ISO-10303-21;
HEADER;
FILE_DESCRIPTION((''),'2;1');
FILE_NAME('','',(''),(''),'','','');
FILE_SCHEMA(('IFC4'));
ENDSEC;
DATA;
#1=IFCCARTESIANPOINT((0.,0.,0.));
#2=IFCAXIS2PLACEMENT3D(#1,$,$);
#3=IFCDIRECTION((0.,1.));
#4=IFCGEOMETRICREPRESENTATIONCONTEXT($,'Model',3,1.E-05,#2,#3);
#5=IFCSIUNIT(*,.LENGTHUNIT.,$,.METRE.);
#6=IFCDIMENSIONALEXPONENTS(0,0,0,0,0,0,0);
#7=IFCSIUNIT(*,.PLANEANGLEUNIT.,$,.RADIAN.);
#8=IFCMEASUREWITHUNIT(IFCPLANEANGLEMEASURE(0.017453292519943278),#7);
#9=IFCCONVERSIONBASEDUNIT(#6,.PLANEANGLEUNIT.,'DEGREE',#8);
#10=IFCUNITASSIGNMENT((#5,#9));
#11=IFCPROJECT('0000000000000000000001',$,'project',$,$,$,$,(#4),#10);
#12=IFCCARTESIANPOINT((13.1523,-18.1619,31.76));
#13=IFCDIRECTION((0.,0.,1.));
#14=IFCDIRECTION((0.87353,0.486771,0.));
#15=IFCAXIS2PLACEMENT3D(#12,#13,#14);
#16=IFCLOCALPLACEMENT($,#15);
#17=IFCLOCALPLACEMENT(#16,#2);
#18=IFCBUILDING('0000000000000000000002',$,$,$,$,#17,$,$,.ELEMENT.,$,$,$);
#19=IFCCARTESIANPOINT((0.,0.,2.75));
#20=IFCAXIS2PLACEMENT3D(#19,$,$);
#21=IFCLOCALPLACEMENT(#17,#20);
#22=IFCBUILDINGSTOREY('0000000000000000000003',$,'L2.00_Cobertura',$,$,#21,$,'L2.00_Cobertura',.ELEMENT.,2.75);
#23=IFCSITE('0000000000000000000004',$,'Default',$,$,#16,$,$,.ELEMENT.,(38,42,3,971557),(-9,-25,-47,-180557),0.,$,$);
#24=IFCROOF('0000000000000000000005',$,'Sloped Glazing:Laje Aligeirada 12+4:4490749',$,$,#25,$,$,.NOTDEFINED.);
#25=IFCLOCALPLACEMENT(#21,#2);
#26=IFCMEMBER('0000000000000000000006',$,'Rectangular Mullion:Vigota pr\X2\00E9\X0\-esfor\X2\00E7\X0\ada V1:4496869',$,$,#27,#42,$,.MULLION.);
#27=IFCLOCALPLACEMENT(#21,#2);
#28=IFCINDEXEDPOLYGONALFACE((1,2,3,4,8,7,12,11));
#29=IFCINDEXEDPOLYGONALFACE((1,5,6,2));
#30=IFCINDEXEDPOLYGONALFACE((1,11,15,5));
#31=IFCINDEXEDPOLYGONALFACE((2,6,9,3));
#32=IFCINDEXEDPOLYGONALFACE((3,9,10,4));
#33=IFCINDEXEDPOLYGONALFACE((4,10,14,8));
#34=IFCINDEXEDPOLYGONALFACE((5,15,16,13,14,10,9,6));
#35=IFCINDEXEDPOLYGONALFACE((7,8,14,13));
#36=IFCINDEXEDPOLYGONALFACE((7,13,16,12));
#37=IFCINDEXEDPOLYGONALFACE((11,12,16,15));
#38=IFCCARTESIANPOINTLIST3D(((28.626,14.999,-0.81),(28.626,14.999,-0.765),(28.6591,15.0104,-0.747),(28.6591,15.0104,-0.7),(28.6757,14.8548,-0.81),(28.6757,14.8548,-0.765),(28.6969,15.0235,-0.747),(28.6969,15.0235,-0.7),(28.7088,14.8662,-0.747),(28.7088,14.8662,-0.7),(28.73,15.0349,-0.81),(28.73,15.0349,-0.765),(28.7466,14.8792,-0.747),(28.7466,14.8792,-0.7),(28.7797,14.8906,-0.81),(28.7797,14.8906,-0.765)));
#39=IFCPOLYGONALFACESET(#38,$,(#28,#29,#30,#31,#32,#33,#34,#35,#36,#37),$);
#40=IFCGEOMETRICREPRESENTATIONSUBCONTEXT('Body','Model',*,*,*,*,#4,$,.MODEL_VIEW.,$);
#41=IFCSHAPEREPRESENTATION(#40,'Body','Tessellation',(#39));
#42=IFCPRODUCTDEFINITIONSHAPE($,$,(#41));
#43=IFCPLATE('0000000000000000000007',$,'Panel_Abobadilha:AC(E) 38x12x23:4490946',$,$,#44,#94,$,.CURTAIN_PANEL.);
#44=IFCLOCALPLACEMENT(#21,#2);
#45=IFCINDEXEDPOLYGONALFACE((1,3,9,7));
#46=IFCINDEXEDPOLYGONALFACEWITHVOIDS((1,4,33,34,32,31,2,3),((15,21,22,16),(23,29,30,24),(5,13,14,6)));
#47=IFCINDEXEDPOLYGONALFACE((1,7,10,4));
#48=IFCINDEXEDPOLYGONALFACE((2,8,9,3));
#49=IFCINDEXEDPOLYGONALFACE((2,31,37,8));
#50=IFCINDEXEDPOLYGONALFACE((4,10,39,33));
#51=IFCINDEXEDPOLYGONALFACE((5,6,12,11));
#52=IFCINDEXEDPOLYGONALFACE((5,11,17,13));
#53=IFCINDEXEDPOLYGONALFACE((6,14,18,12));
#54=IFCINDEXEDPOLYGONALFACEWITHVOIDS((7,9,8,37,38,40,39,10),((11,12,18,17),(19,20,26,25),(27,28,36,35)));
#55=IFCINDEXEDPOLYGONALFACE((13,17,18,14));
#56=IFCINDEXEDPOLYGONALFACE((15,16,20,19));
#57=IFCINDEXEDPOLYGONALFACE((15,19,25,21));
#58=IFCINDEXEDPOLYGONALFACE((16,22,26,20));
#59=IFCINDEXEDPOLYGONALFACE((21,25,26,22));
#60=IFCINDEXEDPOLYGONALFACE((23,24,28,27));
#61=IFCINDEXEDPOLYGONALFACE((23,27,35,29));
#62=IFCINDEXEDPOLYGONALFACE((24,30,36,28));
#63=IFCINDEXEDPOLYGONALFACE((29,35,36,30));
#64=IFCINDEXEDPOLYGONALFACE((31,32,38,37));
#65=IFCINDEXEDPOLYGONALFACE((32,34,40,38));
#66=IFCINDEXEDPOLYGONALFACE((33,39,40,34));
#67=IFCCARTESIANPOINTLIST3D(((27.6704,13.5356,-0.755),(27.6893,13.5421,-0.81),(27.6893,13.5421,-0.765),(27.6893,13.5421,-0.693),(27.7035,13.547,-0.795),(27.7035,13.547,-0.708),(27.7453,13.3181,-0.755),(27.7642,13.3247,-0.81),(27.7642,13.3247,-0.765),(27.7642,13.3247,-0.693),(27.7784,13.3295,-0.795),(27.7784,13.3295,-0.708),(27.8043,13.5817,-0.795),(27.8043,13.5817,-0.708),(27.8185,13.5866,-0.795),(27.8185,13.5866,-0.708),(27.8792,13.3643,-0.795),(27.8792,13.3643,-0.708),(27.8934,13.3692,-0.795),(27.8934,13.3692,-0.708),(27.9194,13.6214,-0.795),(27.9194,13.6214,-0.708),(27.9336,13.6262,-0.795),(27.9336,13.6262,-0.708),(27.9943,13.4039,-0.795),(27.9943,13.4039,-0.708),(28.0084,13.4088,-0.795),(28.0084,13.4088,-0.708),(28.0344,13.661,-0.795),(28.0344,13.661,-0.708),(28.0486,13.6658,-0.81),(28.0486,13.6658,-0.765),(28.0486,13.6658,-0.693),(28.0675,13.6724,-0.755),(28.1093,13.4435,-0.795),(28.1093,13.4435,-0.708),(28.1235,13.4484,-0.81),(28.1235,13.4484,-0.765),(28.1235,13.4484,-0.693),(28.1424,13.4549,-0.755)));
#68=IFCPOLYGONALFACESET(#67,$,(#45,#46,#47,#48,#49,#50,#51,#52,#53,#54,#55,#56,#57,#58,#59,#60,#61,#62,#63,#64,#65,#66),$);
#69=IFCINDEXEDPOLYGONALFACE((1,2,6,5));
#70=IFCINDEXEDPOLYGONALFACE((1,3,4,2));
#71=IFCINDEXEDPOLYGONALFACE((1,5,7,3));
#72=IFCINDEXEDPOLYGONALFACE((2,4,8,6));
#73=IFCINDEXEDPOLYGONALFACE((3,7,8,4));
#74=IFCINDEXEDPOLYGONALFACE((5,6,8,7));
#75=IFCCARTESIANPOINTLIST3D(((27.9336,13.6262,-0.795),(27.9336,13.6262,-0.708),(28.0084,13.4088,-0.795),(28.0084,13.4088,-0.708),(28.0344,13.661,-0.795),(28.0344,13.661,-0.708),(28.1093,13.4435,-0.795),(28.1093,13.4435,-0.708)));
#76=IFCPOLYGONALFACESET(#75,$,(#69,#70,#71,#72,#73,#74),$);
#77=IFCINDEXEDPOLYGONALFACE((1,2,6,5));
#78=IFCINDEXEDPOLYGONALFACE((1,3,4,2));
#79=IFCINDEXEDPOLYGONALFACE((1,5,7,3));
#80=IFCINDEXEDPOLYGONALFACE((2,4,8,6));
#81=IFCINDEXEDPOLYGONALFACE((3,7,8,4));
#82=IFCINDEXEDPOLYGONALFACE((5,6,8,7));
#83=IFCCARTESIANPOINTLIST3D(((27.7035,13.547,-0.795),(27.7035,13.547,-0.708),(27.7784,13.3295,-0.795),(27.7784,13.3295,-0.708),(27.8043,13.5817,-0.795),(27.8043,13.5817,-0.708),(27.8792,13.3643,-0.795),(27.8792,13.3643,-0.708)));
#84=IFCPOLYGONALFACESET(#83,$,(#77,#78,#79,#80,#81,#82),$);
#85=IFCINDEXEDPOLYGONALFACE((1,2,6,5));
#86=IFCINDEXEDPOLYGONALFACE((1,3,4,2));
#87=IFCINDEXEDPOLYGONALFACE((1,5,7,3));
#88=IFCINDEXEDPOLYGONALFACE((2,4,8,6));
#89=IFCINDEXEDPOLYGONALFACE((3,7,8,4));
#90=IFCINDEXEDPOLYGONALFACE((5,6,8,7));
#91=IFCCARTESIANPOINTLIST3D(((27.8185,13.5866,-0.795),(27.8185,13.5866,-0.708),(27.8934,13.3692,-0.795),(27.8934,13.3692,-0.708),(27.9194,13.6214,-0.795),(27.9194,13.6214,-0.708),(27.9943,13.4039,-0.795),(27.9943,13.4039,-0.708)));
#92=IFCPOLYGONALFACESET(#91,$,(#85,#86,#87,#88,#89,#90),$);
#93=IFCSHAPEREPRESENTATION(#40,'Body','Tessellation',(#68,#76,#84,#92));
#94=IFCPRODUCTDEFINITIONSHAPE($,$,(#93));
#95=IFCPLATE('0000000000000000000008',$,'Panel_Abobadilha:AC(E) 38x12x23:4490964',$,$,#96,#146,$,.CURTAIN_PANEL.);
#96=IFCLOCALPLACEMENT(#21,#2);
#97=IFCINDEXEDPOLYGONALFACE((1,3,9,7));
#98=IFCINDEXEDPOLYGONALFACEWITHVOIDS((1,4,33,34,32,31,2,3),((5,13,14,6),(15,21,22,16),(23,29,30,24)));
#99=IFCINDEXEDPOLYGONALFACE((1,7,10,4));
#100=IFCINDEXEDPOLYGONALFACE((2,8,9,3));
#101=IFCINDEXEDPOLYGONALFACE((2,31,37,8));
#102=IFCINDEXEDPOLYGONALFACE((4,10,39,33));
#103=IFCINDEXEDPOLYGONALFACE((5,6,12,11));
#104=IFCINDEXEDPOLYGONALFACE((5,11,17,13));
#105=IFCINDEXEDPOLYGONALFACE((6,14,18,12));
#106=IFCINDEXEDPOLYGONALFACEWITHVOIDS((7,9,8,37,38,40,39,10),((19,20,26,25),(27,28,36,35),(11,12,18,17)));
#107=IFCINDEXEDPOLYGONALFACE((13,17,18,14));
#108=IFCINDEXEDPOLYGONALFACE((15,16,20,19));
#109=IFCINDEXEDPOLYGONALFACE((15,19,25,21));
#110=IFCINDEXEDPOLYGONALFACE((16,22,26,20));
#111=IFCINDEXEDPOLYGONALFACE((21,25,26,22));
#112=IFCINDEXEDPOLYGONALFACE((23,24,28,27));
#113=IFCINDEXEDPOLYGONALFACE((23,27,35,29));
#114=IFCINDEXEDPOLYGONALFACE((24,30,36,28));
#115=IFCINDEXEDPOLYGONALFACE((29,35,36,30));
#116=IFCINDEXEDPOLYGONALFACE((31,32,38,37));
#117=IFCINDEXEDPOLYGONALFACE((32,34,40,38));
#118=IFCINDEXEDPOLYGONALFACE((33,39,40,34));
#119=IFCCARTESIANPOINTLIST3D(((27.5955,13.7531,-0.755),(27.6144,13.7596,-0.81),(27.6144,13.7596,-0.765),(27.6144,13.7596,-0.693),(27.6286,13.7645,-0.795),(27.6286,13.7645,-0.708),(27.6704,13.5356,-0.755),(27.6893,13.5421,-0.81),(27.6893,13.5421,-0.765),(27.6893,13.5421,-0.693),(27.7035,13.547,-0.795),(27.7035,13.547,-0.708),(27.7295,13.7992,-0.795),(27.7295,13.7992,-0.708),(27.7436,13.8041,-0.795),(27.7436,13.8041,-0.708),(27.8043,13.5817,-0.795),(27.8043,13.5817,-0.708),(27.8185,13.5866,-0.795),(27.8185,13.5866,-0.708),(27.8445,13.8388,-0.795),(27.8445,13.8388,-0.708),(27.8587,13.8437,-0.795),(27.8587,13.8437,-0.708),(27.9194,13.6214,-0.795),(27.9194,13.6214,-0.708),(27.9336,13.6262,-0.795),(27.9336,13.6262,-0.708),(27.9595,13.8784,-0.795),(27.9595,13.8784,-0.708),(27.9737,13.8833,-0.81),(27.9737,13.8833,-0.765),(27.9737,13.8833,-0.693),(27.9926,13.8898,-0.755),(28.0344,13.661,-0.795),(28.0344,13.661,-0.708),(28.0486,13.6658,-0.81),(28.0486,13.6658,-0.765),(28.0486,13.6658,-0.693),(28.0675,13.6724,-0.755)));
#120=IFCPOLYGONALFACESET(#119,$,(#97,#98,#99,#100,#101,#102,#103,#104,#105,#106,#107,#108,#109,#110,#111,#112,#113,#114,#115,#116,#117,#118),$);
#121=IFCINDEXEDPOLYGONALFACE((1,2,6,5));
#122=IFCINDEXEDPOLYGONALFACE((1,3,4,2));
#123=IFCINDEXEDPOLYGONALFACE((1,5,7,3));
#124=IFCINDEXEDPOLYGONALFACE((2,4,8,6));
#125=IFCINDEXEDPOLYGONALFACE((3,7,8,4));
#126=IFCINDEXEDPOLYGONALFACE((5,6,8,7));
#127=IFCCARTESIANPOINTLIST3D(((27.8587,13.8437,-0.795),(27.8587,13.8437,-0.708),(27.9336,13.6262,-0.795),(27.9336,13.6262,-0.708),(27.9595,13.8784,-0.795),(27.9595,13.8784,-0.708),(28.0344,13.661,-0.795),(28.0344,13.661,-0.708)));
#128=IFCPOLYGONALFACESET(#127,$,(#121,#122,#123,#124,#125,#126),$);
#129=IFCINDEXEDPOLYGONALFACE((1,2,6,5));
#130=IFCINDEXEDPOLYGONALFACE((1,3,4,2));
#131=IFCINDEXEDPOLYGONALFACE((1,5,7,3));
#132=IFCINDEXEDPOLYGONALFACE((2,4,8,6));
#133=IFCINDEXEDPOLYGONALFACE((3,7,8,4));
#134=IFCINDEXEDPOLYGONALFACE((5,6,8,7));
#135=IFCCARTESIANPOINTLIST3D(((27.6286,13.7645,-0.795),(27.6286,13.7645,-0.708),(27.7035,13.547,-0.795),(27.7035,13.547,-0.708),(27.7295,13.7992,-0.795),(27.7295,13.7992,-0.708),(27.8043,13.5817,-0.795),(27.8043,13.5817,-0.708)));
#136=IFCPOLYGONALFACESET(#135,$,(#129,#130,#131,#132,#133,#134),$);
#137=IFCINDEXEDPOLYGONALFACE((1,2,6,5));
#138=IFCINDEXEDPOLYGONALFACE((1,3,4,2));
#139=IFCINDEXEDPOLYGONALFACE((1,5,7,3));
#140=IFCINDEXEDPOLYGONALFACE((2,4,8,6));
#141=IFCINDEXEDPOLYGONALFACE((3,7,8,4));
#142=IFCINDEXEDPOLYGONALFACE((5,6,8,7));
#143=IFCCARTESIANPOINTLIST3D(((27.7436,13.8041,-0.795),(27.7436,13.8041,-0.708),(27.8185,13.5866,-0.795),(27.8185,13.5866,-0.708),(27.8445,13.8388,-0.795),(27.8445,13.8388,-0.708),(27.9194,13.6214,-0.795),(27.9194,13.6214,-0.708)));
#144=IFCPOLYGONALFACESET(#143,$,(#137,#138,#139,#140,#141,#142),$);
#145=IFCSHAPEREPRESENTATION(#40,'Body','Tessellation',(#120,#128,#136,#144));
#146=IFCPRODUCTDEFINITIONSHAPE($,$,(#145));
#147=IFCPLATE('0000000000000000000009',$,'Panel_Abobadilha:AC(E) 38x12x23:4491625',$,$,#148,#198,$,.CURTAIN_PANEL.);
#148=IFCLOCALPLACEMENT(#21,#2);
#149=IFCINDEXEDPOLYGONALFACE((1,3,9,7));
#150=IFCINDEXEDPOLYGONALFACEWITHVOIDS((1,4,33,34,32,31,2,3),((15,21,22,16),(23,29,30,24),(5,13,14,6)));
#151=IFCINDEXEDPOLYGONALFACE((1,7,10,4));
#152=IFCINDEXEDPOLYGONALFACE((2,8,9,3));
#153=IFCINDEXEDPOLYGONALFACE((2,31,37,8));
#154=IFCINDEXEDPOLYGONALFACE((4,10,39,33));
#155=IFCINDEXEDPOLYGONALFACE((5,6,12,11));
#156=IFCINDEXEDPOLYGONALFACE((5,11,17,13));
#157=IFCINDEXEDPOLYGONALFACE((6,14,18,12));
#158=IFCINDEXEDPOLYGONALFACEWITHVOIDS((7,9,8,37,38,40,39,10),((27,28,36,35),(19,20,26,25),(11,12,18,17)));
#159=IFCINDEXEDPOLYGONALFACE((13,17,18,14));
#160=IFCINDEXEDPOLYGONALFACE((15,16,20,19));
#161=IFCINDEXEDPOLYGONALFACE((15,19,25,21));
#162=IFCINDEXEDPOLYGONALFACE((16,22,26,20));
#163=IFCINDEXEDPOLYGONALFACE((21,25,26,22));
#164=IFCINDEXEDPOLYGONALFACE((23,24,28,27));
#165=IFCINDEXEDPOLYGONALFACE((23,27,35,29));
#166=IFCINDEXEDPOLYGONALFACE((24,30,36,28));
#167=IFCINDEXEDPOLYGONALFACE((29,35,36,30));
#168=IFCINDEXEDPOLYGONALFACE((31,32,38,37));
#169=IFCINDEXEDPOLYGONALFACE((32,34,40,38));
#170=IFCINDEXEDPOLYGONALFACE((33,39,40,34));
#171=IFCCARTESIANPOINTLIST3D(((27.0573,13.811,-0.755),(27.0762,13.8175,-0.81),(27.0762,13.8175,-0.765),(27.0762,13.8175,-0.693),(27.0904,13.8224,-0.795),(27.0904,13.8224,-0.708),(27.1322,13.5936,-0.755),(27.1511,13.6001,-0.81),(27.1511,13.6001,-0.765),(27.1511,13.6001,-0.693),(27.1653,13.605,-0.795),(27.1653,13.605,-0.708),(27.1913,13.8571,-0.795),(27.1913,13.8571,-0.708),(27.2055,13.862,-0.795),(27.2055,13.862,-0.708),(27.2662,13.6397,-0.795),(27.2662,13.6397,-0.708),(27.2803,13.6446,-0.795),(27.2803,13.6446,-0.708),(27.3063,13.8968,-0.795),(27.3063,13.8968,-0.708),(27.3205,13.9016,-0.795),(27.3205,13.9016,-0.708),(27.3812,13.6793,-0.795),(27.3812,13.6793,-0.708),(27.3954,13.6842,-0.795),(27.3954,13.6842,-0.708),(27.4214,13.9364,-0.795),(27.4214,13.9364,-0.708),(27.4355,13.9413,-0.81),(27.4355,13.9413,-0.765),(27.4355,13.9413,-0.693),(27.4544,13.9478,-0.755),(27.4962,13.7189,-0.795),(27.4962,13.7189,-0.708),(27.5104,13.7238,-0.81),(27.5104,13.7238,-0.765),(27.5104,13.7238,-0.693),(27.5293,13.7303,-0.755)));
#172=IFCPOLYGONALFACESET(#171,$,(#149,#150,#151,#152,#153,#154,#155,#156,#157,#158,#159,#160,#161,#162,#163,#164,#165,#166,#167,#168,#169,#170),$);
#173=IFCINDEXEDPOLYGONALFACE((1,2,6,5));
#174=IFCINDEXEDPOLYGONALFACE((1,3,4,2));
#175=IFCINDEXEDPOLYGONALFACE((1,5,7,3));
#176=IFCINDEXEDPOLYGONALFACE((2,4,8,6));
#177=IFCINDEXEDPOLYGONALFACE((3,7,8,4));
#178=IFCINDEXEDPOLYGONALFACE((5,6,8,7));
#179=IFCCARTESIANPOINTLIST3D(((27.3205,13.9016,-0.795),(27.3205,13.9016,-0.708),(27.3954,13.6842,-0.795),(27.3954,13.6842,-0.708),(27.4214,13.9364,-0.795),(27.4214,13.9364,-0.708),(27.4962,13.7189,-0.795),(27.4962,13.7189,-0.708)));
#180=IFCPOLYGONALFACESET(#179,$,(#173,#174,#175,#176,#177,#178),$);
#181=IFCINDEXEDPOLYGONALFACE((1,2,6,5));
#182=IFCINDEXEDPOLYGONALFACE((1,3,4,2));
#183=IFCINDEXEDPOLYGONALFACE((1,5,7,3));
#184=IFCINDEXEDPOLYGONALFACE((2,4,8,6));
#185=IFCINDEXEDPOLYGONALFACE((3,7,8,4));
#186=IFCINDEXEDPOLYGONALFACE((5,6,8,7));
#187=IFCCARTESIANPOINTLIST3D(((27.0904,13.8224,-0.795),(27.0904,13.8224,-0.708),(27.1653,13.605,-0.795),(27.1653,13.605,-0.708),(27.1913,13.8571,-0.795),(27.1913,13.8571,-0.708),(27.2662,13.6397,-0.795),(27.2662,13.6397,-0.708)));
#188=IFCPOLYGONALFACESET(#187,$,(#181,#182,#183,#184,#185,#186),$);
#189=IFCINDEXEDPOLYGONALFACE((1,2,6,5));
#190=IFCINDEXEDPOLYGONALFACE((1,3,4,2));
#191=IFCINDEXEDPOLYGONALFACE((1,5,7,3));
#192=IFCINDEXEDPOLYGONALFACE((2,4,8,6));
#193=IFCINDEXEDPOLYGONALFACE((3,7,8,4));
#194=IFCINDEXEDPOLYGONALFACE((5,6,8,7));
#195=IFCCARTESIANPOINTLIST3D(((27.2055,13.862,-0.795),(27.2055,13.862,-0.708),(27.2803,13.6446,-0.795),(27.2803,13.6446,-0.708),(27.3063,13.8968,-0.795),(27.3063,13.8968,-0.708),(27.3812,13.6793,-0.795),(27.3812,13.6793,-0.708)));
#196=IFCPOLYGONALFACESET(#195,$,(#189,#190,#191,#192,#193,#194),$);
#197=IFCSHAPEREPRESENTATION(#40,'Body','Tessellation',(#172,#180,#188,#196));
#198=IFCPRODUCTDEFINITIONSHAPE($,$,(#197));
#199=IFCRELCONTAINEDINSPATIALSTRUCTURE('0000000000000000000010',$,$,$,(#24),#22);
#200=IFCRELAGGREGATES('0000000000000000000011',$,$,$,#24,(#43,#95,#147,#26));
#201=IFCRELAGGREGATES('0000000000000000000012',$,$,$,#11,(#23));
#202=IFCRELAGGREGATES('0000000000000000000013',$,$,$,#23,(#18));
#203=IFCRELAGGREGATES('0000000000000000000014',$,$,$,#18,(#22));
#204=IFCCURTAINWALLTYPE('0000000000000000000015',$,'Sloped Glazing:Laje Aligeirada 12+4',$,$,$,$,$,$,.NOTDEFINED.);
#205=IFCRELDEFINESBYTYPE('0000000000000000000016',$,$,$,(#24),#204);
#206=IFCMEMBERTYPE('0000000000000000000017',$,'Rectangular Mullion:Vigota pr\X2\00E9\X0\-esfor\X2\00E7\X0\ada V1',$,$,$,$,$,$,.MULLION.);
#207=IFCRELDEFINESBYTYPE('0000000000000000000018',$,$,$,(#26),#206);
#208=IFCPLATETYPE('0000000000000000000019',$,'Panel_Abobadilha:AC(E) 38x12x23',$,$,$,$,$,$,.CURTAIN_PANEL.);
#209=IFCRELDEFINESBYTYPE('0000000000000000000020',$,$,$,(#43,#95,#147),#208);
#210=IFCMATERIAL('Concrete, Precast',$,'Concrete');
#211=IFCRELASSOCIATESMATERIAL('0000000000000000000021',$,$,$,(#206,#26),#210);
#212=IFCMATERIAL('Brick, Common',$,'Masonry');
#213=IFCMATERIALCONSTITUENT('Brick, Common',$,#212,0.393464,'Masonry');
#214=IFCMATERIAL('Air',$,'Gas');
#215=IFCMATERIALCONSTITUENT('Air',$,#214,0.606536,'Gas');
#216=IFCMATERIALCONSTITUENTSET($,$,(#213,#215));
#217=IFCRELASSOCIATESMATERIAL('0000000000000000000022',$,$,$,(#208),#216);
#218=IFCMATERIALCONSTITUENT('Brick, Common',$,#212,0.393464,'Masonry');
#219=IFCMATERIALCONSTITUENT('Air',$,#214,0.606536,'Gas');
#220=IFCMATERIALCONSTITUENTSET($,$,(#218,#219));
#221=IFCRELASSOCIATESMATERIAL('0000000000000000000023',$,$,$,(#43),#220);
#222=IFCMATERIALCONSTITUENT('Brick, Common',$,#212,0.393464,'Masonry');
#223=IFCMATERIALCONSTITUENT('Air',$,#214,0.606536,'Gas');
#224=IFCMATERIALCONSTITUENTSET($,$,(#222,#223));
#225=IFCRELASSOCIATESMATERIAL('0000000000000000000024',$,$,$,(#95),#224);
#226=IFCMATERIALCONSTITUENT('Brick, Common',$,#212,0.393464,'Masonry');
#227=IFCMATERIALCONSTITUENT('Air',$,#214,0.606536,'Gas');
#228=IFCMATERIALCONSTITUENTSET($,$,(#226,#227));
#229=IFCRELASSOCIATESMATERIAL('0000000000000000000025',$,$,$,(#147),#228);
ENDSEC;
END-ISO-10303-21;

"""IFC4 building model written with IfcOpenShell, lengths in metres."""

from ifc_helpers import new_model, entity, si_unit, converted_unit, direction, frame, origin, place, context, subcontext, project, spatial, indexed_curve, outline, extrude, source, transform, mapped, material, constituent, constituent_set, type_object, type_shapes, element, aggregate, save


model = new_model("IFC4")

# Units and contexts
model_context = context("Model", 3, precision=1e-05, world=origin(), true_north=direction((0.0, 1.0)))
body_context = subcontext(model_context, "Body", "Model", "MODEL_VIEW")
ifc_project = project(units=[si_unit("LENGTHUNIT", "METRE"), converted_unit("PLANEANGLEUNIT", "DEGREE", entity("IfcPlaneAngleMeasure", 0.017453292519943278), si_unit("PLANEANGLEUNIT", "RADIAN"), dimensions=[0, 0, 0, 0, 0, 0, 0])], contexts=[model_context])

# Site, building, storey
site_placement = place(None, frame((13.1523, -18.1619, 31.76), z_axis=(0.0, 0.0, 1.0), x_axis=(0.87353, 0.486771, 0.0)))
site = spatial("IfcSite", under=ifc_project, at=site_placement, Name="Default", CompositionType="ELEMENT", RefLatitude=(38, 42, 3, 971557), RefLongitude=(-9, -25, -47, -180557), RefElevation=0.0)
building_placement = place(site_placement, origin())
building = spatial("IfcBuilding", under=site, at=building_placement, CompositionType="ELEMENT")
storey_placement = place(building_placement, frame((0.0, 0.0, 2.75)))
storey = spatial("IfcBuildingStorey", under=building, at=storey_placement, Name="L2.00_Cobertura", LongName="L2.00_Cobertura", CompositionType="ELEMENT", Elevation=2.75)

# Roof, member, plates
curtain_wall_type = type_object("IfcCurtainWallType", Name="Sloped Glazing:Laje Aligeirada 12+4", PredefinedType="NOTDEFINED")
roof_placement = place(storey_placement, frame((0.0, 0.0, -2.75)))
roof = element("IfcRoof", 1, at=roof_placement, inside=storey, type_object=curtain_wall_type, Name="Sloped Glazing:Laje Aligeirada 12+4:4490749", PredefinedType="NOTDEFINED")
ifc_material_1 = material(Name="Concrete, Precast", Category="Concrete")
member_type_1 = type_object("IfcMemberType", Name="Rectangular Mullion:Vigota pré-esforçada V1", PredefinedType="MULLION", material=ifc_material_1)
shared_shape_1 = source(origin(), body_context, "Body", "SweptSolid", [
    extrude(outline(indexed_curve([(-0.055, -0.0545), (0.055, -0.0545), (0.055, -0.0095), (0.02, 0.0085), (0.02, 0.0555), (-0.02, 0.0555), (-0.02, 0.0085), (-0.055, -0.0095), (-0.055, -0.0545)], self_intersect=False)), frame((0.0, -0.0545, -0.1526), z_axis=(0.0, 0.0, 1.0), x_axis=(-1.0, 0.0, 0.0)), (0.0, 0.0, 1.0), 0.1526),
])
type_shapes(member_type_1, [shared_shape_1])
member_1_placement = place(roof_placement, frame((28.678, 15.017, 1.94), z_axis=(-0.325568, 0.945519, 0.0), x_axis=(0.945519, 0.325568, 0.0)))
member_1 = element("IfcMember", 2, at=member_1_placement, type_object=member_type_1, material=ifc_material_1, Name="Rectangular Mullion:Vigota pré-esforçada V1:4496869", PredefinedType="MULLION", context=body_context, shape_type="MappedRepresentation", body=[
    mapped(shared_shape_1, transform((0.0, 0.0, 0.0), scale=1.0)),
])
ifc_material_2 = material(Name="Brick, Common", Category="Masonry")
ifc_constituent_1 = constituent(ifc_material_2, Name="Brick, Common", Category="Masonry", fraction=0.393464)
ifc_material_3 = material(Name="Air", Category="Gas")
ifc_constituent_2 = constituent(ifc_material_3, Name="Air", Category="Gas", fraction=0.606536)
ifc_constituent_set_1 = constituent_set(constituents=[ifc_constituent_1, ifc_constituent_2])
ifc_constituent_3 = constituent(ifc_material_2, Name="Brick, Common", Category="Masonry", fraction=0.393464)
ifc_constituent_4 = constituent(ifc_material_3, Name="Air", Category="Gas", fraction=0.606536)
ifc_constituent_set_2 = constituent_set(constituents=[ifc_constituent_3, ifc_constituent_4])
plate_type = type_object("IfcPlateType", Name="Panel_Abobadilha:AC(E) 38x12x23", PredefinedType="CURTAIN_PANEL", material=ifc_constituent_set_2)
shared_shape_2 = source(origin(), body_context, "Body", "SweptSolid", [
    extrude(outline(indexed_curve([(-0.19, -0.0543), (0.19, -0.0543), (0.19, -0.0093), (0.21, 0.0007), (0.19, 0.0628), (-0.19, 0.0628), (-0.21, 0.0007), (-0.19, -0.0093), (-0.19, -0.0543)], self_intersect=False), holes=[indexed_curve([(-0.0683, 0.0477), (-0.0683, -0.0393), (-0.175, -0.0393), (-0.175, 0.0477), (-0.0683, 0.0477)], self_intersect=False), indexed_curve([(0.0533, 0.0477), (0.0533, -0.0393), (-0.0533, -0.0393), (-0.0533, 0.0477), (0.0533, 0.0477)], self_intersect=False), indexed_curve([(0.175, 0.0477), (0.175, -0.0393), (0.0683, -0.0393), (0.0683, 0.0477), (0.175, 0.0477)], self_intersect=False)]), frame((0.0, 0.0543, 0.0)), (0.0, 0.0, 1.0), 0.23),
    extrude(outline(indexed_curve([(-0.0533, -0.0435), (0.0533, -0.0435), (0.0533, 0.0435), (-0.0533, 0.0435), (-0.0533, -0.0435)], self_intersect=False)), frame((0.1217, 0.0585, 0.0), z_axis=(0.0, 0.0, 1.0), x_axis=(-1.0, 0.0, 0.0)), (0.0, 0.0, 1.0), 0.23),
    extrude(outline(indexed_curve([(-0.0533, -0.0435), (0.0533, -0.0435), (0.0533, 0.0435), (-0.0533, 0.0435), (-0.0533, -0.0435)], self_intersect=False)), frame((-0.1217, 0.0585, 0.0), z_axis=(0.0, 0.0, 1.0), x_axis=(-1.0, 0.0, 0.0)), (0.0, 0.0, 1.0), 0.23),
    extrude(outline(indexed_curve([(-0.0533, -0.0435), (0.0533, -0.0435), (0.0533, 0.0435), (-0.0533, 0.0435), (-0.0533, -0.0435)], self_intersect=False)), frame((0.0, 0.0585, 0.0), z_axis=(0.0, 0.0, 1.0), x_axis=(-1.0, 0.0, 0.0)), (0.0, 0.0, 1.0), 0.23),
])
type_shapes(plate_type, [shared_shape_2])
plate_1_placement = place(roof_placement, frame((27.869, 13.604, 1.94), z_axis=(0.325568, -0.945519, 0.0), x_axis=(0.945519, 0.325568, 0.0)))
plate_1 = element("IfcPlate", 3, at=plate_1_placement, type_object=plate_type, material=ifc_constituent_set_1, Name="Panel_Abobadilha:AC(E) 38x12x23:4490946", PredefinedType="CURTAIN_PANEL", context=body_context, shape_type="MappedRepresentation", body=[
    mapped(shared_shape_2, transform((0.0, 0.0, 0.0), scale=1.0)),
])
ifc_constituent_5 = constituent(ifc_material_2, Name="Brick, Common", Category="Masonry", fraction=0.393464)
ifc_constituent_6 = constituent(ifc_material_3, Name="Air", Category="Gas", fraction=0.606536)
ifc_constituent_set_3 = constituent_set(constituents=[ifc_constituent_5, ifc_constituent_6])
plate_2_placement = place(roof_placement, frame((27.7941, 13.8215, 1.94), z_axis=(0.325568, -0.945519, 0.0), x_axis=(0.945519, 0.325568, 0.0)))
plate_2 = element("IfcPlate", 4, at=plate_2_placement, type_object=plate_type, material=ifc_constituent_set_3, Name="Panel_Abobadilha:AC(E) 38x12x23:4490964", PredefinedType="CURTAIN_PANEL", context=body_context, shape_type="MappedRepresentation", body=[
    mapped(shared_shape_2, transform((0.0, 0.0, 0.0), scale=1.0)),
])
ifc_constituent_7 = constituent(ifc_material_2, Name="Brick, Common", Category="Masonry", fraction=0.393464)
ifc_constituent_8 = constituent(ifc_material_3, Name="Air", Category="Gas", fraction=0.606536)
ifc_constituent_set_4 = constituent_set(constituents=[ifc_constituent_7, ifc_constituent_8])
plate_3_placement = place(roof_placement, frame((27.2559, 13.8794, 1.94), z_axis=(0.325568, -0.945519, 0.0), x_axis=(0.945519, 0.325568, 0.0)))
plate_3 = element("IfcPlate", 5, at=plate_3_placement, type_object=plate_type, material=ifc_constituent_set_4, Name="Panel_Abobadilha:AC(E) 38x12x23:4491625", PredefinedType="CURTAIN_PANEL", context=body_context, shape_type="MappedRepresentation", body=[
    mapped(shared_shape_2, transform((0.0, 0.0, 0.0), scale=1.0)),
])
aggregate(roof, [plate_1, plate_2, plate_3, member_1])

save(model, "model.ifc")
